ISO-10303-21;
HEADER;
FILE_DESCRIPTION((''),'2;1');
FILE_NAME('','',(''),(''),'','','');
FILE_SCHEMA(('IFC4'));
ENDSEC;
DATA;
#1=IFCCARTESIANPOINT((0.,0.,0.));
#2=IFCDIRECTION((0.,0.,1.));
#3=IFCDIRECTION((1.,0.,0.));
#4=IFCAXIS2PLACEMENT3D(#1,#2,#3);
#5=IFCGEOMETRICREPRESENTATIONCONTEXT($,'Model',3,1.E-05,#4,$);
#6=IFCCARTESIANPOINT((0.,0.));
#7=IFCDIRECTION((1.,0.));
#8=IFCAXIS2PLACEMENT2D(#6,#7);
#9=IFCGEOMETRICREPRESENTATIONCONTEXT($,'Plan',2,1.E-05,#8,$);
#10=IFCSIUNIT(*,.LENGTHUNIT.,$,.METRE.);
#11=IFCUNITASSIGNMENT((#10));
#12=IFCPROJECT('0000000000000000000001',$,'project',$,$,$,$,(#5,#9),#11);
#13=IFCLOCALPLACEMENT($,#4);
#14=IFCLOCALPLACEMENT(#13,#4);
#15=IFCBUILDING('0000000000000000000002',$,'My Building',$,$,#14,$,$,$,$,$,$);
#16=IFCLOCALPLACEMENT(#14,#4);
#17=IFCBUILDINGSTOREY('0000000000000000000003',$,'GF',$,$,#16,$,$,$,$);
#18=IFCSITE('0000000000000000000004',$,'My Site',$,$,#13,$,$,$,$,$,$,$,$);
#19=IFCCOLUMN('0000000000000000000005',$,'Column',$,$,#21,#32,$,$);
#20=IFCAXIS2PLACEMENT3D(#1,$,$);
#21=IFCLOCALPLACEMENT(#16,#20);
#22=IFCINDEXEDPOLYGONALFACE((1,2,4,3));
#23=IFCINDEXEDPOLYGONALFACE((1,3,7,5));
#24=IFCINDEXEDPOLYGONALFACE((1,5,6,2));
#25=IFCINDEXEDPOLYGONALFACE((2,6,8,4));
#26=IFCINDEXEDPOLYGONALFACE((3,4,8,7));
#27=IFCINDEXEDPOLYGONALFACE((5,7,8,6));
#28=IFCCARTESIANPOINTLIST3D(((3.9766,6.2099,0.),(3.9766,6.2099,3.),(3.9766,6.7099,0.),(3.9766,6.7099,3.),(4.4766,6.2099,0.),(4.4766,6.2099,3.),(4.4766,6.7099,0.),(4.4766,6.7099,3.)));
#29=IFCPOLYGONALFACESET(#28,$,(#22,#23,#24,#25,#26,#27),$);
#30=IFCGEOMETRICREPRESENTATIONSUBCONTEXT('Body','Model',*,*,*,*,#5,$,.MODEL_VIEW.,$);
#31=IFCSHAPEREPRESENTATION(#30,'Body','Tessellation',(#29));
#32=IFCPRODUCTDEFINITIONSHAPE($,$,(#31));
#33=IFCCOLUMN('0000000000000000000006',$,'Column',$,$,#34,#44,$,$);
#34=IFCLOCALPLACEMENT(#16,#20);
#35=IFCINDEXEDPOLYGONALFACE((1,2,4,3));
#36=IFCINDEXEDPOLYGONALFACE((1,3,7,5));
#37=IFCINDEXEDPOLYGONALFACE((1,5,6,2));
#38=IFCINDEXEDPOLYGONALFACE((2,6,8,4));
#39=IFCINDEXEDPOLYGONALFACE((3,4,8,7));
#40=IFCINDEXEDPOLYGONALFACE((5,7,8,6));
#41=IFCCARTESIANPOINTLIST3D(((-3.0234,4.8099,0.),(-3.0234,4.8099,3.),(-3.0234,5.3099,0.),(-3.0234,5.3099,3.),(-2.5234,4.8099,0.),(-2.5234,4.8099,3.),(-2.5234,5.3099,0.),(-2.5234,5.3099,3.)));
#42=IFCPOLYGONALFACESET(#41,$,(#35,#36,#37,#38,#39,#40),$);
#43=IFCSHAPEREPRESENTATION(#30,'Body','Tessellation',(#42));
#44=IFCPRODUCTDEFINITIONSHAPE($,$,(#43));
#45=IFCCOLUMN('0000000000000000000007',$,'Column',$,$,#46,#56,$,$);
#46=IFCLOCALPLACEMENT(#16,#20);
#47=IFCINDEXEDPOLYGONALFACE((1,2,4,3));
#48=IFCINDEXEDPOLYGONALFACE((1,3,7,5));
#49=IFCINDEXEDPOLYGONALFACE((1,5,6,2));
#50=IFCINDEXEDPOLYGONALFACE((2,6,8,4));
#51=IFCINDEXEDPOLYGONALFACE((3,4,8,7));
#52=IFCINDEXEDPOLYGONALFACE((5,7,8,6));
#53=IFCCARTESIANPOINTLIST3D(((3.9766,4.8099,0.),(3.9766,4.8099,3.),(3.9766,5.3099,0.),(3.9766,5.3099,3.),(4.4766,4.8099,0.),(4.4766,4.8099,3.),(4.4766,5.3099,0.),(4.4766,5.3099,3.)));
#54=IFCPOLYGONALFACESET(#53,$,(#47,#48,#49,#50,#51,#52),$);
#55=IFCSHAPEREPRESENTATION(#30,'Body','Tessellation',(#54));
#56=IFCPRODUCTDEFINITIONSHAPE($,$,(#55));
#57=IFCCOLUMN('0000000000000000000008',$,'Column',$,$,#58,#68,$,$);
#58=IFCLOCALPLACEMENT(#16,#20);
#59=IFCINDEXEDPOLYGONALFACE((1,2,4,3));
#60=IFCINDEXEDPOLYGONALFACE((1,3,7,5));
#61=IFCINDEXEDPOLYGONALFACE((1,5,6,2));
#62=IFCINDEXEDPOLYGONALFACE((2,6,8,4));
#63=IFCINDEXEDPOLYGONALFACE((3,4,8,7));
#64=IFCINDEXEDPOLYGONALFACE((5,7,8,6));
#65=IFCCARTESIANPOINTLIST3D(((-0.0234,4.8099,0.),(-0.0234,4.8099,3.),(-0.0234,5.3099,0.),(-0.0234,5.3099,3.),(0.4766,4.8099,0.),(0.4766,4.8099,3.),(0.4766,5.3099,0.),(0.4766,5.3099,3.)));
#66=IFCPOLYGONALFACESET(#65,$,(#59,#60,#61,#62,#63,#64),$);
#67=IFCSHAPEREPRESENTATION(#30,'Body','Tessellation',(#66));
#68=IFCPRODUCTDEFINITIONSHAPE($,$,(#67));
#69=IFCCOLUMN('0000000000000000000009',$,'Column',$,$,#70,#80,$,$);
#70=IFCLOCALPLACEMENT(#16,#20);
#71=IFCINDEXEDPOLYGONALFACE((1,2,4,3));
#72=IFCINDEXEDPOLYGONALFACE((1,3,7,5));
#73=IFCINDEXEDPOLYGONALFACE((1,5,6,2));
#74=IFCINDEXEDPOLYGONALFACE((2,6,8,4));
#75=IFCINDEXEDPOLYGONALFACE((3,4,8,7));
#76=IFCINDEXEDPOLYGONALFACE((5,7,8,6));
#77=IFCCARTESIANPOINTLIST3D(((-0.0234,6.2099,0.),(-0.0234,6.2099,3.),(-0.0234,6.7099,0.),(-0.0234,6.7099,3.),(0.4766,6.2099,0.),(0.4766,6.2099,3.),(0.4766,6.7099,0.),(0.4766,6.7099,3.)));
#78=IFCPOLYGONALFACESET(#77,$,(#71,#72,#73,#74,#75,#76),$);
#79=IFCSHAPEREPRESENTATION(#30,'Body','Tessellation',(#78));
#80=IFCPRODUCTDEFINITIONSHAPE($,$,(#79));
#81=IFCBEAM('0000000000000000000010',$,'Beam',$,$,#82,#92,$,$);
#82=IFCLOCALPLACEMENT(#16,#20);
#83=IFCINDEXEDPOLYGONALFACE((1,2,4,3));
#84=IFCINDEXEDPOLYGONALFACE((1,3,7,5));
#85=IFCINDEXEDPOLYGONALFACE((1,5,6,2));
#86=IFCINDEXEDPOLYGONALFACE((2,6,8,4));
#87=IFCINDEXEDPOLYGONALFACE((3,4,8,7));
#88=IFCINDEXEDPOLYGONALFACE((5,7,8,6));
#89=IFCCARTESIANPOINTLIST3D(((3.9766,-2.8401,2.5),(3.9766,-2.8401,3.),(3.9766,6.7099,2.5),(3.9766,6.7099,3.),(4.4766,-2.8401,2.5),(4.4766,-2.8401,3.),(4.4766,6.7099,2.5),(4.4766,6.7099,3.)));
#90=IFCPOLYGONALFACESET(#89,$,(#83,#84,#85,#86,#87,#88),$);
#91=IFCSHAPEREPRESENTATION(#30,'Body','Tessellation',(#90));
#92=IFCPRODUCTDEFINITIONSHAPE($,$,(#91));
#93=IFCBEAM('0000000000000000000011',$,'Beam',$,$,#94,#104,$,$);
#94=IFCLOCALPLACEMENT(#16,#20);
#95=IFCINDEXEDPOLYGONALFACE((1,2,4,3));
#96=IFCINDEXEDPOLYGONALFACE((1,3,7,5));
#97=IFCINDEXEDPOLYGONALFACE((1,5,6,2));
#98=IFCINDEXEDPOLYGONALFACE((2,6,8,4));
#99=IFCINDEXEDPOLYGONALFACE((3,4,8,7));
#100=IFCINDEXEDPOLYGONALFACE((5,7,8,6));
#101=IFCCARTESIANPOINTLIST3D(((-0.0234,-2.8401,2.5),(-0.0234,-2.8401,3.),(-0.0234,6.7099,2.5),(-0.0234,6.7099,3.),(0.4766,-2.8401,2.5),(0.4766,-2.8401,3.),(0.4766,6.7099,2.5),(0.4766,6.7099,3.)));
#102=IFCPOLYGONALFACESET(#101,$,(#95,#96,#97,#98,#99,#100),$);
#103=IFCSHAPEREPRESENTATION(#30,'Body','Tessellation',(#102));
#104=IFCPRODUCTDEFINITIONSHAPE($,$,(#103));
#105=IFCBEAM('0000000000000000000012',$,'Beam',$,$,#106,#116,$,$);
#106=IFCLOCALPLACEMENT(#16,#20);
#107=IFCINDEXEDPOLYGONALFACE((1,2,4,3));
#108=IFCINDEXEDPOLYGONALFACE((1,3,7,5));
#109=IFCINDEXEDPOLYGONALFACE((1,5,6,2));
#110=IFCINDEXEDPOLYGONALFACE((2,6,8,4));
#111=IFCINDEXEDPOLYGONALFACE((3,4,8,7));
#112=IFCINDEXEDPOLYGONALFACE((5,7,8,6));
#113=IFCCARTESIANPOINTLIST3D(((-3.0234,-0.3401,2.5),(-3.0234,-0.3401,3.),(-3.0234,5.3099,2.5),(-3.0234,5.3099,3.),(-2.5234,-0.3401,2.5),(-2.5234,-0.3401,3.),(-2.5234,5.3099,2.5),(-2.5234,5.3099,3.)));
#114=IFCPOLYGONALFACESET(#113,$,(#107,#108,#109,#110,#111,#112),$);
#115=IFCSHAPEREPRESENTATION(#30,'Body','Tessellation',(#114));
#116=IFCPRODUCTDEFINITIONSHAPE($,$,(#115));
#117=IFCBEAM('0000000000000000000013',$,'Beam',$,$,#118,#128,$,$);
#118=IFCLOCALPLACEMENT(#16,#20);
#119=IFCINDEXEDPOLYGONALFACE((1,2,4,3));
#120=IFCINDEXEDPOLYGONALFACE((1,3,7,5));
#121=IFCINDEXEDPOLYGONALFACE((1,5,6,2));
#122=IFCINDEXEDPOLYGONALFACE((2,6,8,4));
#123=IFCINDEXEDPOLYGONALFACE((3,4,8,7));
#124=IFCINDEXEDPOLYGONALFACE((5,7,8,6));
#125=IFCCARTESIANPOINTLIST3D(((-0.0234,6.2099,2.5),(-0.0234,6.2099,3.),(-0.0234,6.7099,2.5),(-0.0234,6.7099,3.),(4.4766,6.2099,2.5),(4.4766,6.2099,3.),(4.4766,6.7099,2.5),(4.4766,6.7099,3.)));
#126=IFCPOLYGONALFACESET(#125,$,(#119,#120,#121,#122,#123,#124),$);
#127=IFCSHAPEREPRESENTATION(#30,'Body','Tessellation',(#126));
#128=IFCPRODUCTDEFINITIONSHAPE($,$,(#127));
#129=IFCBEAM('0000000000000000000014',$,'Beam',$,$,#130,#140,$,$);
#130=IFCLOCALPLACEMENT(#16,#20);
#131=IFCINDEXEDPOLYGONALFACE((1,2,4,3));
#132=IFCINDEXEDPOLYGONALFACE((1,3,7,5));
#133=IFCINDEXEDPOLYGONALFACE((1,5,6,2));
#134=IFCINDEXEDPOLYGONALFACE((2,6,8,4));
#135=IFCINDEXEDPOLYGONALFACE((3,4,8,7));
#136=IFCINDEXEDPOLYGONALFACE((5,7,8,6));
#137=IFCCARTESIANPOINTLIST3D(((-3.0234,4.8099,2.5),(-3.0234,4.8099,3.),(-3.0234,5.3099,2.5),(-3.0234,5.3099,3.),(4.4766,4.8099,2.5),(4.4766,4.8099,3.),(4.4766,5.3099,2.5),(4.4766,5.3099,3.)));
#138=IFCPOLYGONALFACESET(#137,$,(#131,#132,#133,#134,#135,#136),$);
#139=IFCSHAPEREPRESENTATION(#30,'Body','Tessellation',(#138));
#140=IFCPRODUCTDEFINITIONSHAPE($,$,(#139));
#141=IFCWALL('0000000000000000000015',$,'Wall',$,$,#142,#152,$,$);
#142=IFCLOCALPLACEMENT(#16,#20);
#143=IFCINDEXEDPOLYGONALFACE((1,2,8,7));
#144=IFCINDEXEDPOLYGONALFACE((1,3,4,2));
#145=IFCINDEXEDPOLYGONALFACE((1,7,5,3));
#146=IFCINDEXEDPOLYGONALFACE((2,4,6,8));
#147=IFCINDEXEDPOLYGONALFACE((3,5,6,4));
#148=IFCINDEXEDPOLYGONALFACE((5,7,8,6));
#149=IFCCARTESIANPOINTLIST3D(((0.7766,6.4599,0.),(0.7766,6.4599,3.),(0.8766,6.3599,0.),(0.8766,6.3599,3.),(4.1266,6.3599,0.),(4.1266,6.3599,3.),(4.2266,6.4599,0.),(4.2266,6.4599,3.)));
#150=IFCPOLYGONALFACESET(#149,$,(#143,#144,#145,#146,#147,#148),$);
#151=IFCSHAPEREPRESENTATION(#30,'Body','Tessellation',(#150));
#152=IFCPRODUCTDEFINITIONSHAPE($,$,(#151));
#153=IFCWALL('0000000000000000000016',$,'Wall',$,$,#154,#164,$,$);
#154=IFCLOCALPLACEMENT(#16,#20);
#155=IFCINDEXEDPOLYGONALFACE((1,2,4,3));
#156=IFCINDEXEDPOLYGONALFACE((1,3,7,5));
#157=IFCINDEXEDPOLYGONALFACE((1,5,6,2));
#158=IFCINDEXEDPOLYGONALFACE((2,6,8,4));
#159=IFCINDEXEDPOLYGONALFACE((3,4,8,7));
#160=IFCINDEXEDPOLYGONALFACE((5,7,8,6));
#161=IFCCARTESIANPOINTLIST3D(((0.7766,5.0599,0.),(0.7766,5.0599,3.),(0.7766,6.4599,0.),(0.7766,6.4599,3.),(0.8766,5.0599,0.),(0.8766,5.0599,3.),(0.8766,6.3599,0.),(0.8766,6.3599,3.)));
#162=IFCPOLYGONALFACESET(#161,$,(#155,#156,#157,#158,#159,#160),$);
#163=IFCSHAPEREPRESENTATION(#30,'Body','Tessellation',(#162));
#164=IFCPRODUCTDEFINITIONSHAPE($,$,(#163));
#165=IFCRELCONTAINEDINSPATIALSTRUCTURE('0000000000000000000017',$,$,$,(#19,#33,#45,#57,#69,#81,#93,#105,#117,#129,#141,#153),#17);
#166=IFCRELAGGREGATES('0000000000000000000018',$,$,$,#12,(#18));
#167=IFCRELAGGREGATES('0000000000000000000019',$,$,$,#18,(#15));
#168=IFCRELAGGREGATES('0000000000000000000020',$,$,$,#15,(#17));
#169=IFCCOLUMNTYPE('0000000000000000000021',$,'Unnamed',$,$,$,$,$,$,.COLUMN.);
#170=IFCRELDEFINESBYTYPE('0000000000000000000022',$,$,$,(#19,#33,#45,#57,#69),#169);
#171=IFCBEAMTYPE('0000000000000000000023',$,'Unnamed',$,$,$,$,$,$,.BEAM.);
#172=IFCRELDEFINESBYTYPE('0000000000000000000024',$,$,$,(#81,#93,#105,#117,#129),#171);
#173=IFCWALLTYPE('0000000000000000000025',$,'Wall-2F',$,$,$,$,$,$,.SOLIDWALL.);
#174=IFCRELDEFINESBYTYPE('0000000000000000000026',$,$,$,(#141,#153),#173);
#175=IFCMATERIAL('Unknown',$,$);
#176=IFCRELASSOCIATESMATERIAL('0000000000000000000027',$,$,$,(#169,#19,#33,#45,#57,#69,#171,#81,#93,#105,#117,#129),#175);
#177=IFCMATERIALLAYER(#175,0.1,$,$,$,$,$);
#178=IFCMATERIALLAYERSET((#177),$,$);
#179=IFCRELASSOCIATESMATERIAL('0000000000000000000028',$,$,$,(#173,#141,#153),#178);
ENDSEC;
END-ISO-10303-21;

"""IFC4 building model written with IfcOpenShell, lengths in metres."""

from ifc_helpers import new_model, si_unit, frame, origin_with_axes, origin_2d_with_axis, place, context, subcontext, project, spatial, line, indexed_curve, rectangle, outline, extrude, material, layer, layer_set, layer_usage, material_profile, profile_set, profile_usage, type_object, element, save


model = new_model("IFC4")

# Units and contexts
model_context = context("Model", 3, precision=1e-05, world=origin_with_axes())
plan_context = context("Plan", 2, precision=1e-05, world=origin_2d_with_axis())
body_context_1 = subcontext(model_context, "Body", "Model", "MODEL_VIEW")
ifc_project = project(units=[si_unit("LENGTHUNIT", "METRE")], contexts=[model_context, plan_context])

# Site, building, storey
site_placement = place(None, origin_with_axes())
site = spatial("IfcSite", under=ifc_project, at=site_placement, Name="My Site")
building_placement = place(site_placement, origin_with_axes())
building = spatial("IfcBuilding", under=site, at=building_placement, Name="My Building")
storey_placement = place(building_placement, origin_with_axes())
storey = spatial("IfcBuildingStorey", under=building, at=storey_placement, Name="GF")

# Columns
ifc_material_1 = material(Name="Unknown")
ifc_material_profile_1 = material_profile(ifc_material_1, rectangle(XDim=0.5, YDim=0.5))
ifc_profile_set_1 = profile_set([ifc_material_profile_1])
ifc_profile_usage_1 = profile_usage(ifc_profile_set_1, cardinal=5)
column_type = type_object("IfcColumnType", Name="Unnamed", PredefinedType="COLUMN", material=ifc_profile_set_1)
column_1_placement = place(storey_placement, frame((4.2266, 6.4599, 0.0), z_axis=(0.0, 0.0, 1.0), x_axis=(1.0, 0.0, 0.0)))
element("IfcColumn", 1, at=column_1_placement, inside=storey, type_object=column_type, material=ifc_profile_usage_1, Name="Column", context=body_context_1, shape_type="SweptSolid", body=[
    extrude(rectangle(XDim=0.5, YDim=0.5), origin_with_axes(), (0.0, 0.0, 1.0), 3.0),
])
ifc_profile_usage_2 = profile_usage(ifc_profile_set_1, cardinal=5)
column_2_placement = place(storey_placement, frame((-2.7734, 5.0599, 0.0), z_axis=(0.0, 0.0, 1.0), x_axis=(1.0, 0.0, 0.0)))
element("IfcColumn", 2, at=column_2_placement, inside=storey, type_object=column_type, material=ifc_profile_usage_2, Name="Column", context=body_context_1, shape_type="SweptSolid", body=[
    extrude(rectangle(XDim=0.5, YDim=0.5), origin_with_axes(), (0.0, 0.0, 1.0), 3.0),
])
ifc_profile_usage_3 = profile_usage(ifc_profile_set_1, cardinal=5)
column_3_placement = place(storey_placement, frame((4.2266, 5.0599, 0.0), z_axis=(0.0, 0.0, 1.0), x_axis=(1.0, 0.0, 0.0)))
element("IfcColumn", 3, at=column_3_placement, inside=storey, type_object=column_type, material=ifc_profile_usage_3, Name="Column", context=body_context_1, shape_type="SweptSolid", body=[
    extrude(rectangle(XDim=0.5, YDim=0.5), origin_with_axes(), (0.0, 0.0, 1.0), 3.0),
])
ifc_profile_usage_4 = profile_usage(ifc_profile_set_1, cardinal=5)
column_4_placement = place(storey_placement, frame((0.2266, 5.0599, 0.0), z_axis=(0.0, 0.0, 1.0), x_axis=(1.0, 0.0, 0.0)))
element("IfcColumn", 4, at=column_4_placement, inside=storey, type_object=column_type, material=ifc_profile_usage_4, Name="Column", context=body_context_1, shape_type="SweptSolid", body=[
    extrude(rectangle(XDim=0.5, YDim=0.5), origin_with_axes(), (0.0, 0.0, 1.0), 3.0),
])
ifc_profile_usage_5 = profile_usage(ifc_profile_set_1, cardinal=5)
column_5_placement = place(storey_placement, frame((0.2266, 6.4599, 0.0), z_axis=(0.0, 0.0, 1.0), x_axis=(1.0, 0.0, 0.0)))
element("IfcColumn", 5, at=column_5_placement, inside=storey, type_object=column_type, material=ifc_profile_usage_5, Name="Column", context=body_context_1, shape_type="SweptSolid", body=[
    extrude(rectangle(XDim=0.5, YDim=0.5), origin_with_axes(), (0.0, 0.0, 1.0), 3.0),
])

# Beams
ifc_material_profile_2 = material_profile(ifc_material_1, rectangle(XDim=0.5, YDim=0.5))
ifc_profile_set_2 = profile_set([ifc_material_profile_2])
ifc_profile_usage_6 = profile_usage(ifc_profile_set_2, cardinal=7)
beam_type = type_object("IfcBeamType", Name="Unnamed", PredefinedType="BEAM", material=ifc_profile_set_2)
beam_1_placement = place(storey_placement, frame((4.4766, 6.7099, 3.0), z_axis=(0.0, -1.0, 0.0), x_axis=(1.0, 0.0, 0.0)))
element("IfcBeam", 6, at=beam_1_placement, inside=storey, type_object=beam_type, material=ifc_profile_usage_6, Name="Beam", context=body_context_1, shape_type="SweptSolid", body=[
    extrude(rectangle(XDim=0.5, YDim=0.5), frame((-0.25, -0.25, 0.0), z_axis=(0.0, 0.0, 1.0), x_axis=(1.0, 0.0, 0.0)), (0.0, 0.0, 1.0), 9.55),
])
ifc_profile_usage_7 = profile_usage(ifc_profile_set_2, cardinal=7)
beam_2_placement = place(storey_placement, frame((0.4766, 6.7099, 3.0), z_axis=(0.0, -1.0, 0.0), x_axis=(1.0, 0.0, 0.0)))
element("IfcBeam", 7, at=beam_2_placement, inside=storey, type_object=beam_type, material=ifc_profile_usage_7, Name="Beam", context=body_context_1, shape_type="SweptSolid", body=[
    extrude(rectangle(XDim=0.5, YDim=0.5), frame((-0.25, -0.25, 0.0), z_axis=(0.0, 0.0, 1.0), x_axis=(1.0, 0.0, 0.0)), (0.0, 0.0, 1.0), 9.55),
])
ifc_profile_usage_8 = profile_usage(ifc_profile_set_2, cardinal=7)
beam_3_placement = place(storey_placement, frame((-2.5234, 5.3099, 3.0), z_axis=(0.0, -1.0, 0.0), x_axis=(1.0, 0.0, 0.0)))
element("IfcBeam", 8, at=beam_3_placement, inside=storey, type_object=beam_type, material=ifc_profile_usage_8, Name="Beam", context=body_context_1, shape_type="SweptSolid", body=[
    extrude(rectangle(XDim=0.5, YDim=0.5), frame((-0.25, -0.25, 0.0), z_axis=(0.0, 0.0, 1.0), x_axis=(1.0, 0.0, 0.0)), (0.0, 0.0, 1.0), 5.65),
])
ifc_profile_usage_9 = profile_usage(ifc_profile_set_2, cardinal=7)
beam_4_placement = place(storey_placement, frame((4.4766, 6.2099, 3.0), z_axis=(-1.0, 0.0, 0.0), x_axis=(0.0, -1.0, 0.0)))
element("IfcBeam", 9, at=beam_4_placement, inside=storey, type_object=beam_type, material=ifc_profile_usage_9, Name="Beam", context=body_context_1, shape_type="SweptSolid", body=[
    extrude(rectangle(XDim=0.5, YDim=0.5), frame((-0.25, -0.25, 0.0), z_axis=(0.0, 0.0, 1.0), x_axis=(1.0, 0.0, 0.0)), (0.0, 0.0, 1.0), 4.5),
])
ifc_profile_usage_10 = profile_usage(ifc_profile_set_2, cardinal=7)
beam_5_placement = place(storey_placement, frame((-3.0234, 5.3099, 3.0), z_axis=(1.0, 0.0, 0.0), x_axis=(0.0, 1.0, 0.0)))
element("IfcBeam", 10, at=beam_5_placement, inside=storey, type_object=beam_type, material=ifc_profile_usage_10, Name="Beam", context=body_context_1, shape_type="SweptSolid", body=[
    extrude(rectangle(XDim=0.5, YDim=0.5), frame((-0.25, -0.25, 0.0), z_axis=(0.0, 0.0, 1.0), x_axis=(1.0, 0.0, 0.0)), (0.0, 0.0, 1.0), 7.5),
])

# Walls
ifc_layer_1 = layer(ifc_material_1, 0.1)
ifc_layer_set_1 = layer_set([ifc_layer_1])
ifc_layer_usage_1 = layer_usage(ifc_layer_set_1, "AXIS2", "POSITIVE", 0.0)
wall_type = type_object("IfcWallType", Name="Wall-2F", PredefinedType="SOLIDWALL", material=ifc_layer_set_1)
wall_1_placement = place(storey_placement, frame((4.2266, 6.4599, 0.0), z_axis=(0.0, 0.0, 1.0), x_axis=(-1.0, 0.0, 0.0)))
element("IfcWall", 11, at=wall_1_placement, inside=storey, type_object=wall_type, material=ifc_layer_usage_1, Name="Wall", context=body_context_1, shape_type="SweptSolid", body=[
    extrude(outline(indexed_curve([(0.0, 0.0), (0.1, 0.1), (3.35, 0.1), (3.45, 0.0)], segments=[line(1, 2, 3, 4, 1)])), origin_with_axes(), (0.0, 0.0, 1.0), 3.0),
])
ifc_layer_usage_2 = layer_usage(ifc_layer_set_1, "AXIS2", "POSITIVE", 0.0)
wall_2_placement = place(storey_placement, frame((0.7766, 6.4599, 0.0), z_axis=(0.0, 0.0, 1.0), x_axis=(0.0, -1.0, 0.0)))
element("IfcWall", 12, at=wall_2_placement, inside=storey, type_object=wall_type, material=ifc_layer_usage_2, Name="Wall", context=body_context_1, shape_type="SweptSolid", body=[
    extrude(outline(indexed_curve([(0.0, 0.0), (0.1, 0.1), (1.4, 0.1), (1.4, 0.0)], segments=[line(1, 2, 3, 4, 1)])), origin_with_axes(), (0.0, 0.0, 1.0), 3.0),
])

save(model, "model.ifc")
